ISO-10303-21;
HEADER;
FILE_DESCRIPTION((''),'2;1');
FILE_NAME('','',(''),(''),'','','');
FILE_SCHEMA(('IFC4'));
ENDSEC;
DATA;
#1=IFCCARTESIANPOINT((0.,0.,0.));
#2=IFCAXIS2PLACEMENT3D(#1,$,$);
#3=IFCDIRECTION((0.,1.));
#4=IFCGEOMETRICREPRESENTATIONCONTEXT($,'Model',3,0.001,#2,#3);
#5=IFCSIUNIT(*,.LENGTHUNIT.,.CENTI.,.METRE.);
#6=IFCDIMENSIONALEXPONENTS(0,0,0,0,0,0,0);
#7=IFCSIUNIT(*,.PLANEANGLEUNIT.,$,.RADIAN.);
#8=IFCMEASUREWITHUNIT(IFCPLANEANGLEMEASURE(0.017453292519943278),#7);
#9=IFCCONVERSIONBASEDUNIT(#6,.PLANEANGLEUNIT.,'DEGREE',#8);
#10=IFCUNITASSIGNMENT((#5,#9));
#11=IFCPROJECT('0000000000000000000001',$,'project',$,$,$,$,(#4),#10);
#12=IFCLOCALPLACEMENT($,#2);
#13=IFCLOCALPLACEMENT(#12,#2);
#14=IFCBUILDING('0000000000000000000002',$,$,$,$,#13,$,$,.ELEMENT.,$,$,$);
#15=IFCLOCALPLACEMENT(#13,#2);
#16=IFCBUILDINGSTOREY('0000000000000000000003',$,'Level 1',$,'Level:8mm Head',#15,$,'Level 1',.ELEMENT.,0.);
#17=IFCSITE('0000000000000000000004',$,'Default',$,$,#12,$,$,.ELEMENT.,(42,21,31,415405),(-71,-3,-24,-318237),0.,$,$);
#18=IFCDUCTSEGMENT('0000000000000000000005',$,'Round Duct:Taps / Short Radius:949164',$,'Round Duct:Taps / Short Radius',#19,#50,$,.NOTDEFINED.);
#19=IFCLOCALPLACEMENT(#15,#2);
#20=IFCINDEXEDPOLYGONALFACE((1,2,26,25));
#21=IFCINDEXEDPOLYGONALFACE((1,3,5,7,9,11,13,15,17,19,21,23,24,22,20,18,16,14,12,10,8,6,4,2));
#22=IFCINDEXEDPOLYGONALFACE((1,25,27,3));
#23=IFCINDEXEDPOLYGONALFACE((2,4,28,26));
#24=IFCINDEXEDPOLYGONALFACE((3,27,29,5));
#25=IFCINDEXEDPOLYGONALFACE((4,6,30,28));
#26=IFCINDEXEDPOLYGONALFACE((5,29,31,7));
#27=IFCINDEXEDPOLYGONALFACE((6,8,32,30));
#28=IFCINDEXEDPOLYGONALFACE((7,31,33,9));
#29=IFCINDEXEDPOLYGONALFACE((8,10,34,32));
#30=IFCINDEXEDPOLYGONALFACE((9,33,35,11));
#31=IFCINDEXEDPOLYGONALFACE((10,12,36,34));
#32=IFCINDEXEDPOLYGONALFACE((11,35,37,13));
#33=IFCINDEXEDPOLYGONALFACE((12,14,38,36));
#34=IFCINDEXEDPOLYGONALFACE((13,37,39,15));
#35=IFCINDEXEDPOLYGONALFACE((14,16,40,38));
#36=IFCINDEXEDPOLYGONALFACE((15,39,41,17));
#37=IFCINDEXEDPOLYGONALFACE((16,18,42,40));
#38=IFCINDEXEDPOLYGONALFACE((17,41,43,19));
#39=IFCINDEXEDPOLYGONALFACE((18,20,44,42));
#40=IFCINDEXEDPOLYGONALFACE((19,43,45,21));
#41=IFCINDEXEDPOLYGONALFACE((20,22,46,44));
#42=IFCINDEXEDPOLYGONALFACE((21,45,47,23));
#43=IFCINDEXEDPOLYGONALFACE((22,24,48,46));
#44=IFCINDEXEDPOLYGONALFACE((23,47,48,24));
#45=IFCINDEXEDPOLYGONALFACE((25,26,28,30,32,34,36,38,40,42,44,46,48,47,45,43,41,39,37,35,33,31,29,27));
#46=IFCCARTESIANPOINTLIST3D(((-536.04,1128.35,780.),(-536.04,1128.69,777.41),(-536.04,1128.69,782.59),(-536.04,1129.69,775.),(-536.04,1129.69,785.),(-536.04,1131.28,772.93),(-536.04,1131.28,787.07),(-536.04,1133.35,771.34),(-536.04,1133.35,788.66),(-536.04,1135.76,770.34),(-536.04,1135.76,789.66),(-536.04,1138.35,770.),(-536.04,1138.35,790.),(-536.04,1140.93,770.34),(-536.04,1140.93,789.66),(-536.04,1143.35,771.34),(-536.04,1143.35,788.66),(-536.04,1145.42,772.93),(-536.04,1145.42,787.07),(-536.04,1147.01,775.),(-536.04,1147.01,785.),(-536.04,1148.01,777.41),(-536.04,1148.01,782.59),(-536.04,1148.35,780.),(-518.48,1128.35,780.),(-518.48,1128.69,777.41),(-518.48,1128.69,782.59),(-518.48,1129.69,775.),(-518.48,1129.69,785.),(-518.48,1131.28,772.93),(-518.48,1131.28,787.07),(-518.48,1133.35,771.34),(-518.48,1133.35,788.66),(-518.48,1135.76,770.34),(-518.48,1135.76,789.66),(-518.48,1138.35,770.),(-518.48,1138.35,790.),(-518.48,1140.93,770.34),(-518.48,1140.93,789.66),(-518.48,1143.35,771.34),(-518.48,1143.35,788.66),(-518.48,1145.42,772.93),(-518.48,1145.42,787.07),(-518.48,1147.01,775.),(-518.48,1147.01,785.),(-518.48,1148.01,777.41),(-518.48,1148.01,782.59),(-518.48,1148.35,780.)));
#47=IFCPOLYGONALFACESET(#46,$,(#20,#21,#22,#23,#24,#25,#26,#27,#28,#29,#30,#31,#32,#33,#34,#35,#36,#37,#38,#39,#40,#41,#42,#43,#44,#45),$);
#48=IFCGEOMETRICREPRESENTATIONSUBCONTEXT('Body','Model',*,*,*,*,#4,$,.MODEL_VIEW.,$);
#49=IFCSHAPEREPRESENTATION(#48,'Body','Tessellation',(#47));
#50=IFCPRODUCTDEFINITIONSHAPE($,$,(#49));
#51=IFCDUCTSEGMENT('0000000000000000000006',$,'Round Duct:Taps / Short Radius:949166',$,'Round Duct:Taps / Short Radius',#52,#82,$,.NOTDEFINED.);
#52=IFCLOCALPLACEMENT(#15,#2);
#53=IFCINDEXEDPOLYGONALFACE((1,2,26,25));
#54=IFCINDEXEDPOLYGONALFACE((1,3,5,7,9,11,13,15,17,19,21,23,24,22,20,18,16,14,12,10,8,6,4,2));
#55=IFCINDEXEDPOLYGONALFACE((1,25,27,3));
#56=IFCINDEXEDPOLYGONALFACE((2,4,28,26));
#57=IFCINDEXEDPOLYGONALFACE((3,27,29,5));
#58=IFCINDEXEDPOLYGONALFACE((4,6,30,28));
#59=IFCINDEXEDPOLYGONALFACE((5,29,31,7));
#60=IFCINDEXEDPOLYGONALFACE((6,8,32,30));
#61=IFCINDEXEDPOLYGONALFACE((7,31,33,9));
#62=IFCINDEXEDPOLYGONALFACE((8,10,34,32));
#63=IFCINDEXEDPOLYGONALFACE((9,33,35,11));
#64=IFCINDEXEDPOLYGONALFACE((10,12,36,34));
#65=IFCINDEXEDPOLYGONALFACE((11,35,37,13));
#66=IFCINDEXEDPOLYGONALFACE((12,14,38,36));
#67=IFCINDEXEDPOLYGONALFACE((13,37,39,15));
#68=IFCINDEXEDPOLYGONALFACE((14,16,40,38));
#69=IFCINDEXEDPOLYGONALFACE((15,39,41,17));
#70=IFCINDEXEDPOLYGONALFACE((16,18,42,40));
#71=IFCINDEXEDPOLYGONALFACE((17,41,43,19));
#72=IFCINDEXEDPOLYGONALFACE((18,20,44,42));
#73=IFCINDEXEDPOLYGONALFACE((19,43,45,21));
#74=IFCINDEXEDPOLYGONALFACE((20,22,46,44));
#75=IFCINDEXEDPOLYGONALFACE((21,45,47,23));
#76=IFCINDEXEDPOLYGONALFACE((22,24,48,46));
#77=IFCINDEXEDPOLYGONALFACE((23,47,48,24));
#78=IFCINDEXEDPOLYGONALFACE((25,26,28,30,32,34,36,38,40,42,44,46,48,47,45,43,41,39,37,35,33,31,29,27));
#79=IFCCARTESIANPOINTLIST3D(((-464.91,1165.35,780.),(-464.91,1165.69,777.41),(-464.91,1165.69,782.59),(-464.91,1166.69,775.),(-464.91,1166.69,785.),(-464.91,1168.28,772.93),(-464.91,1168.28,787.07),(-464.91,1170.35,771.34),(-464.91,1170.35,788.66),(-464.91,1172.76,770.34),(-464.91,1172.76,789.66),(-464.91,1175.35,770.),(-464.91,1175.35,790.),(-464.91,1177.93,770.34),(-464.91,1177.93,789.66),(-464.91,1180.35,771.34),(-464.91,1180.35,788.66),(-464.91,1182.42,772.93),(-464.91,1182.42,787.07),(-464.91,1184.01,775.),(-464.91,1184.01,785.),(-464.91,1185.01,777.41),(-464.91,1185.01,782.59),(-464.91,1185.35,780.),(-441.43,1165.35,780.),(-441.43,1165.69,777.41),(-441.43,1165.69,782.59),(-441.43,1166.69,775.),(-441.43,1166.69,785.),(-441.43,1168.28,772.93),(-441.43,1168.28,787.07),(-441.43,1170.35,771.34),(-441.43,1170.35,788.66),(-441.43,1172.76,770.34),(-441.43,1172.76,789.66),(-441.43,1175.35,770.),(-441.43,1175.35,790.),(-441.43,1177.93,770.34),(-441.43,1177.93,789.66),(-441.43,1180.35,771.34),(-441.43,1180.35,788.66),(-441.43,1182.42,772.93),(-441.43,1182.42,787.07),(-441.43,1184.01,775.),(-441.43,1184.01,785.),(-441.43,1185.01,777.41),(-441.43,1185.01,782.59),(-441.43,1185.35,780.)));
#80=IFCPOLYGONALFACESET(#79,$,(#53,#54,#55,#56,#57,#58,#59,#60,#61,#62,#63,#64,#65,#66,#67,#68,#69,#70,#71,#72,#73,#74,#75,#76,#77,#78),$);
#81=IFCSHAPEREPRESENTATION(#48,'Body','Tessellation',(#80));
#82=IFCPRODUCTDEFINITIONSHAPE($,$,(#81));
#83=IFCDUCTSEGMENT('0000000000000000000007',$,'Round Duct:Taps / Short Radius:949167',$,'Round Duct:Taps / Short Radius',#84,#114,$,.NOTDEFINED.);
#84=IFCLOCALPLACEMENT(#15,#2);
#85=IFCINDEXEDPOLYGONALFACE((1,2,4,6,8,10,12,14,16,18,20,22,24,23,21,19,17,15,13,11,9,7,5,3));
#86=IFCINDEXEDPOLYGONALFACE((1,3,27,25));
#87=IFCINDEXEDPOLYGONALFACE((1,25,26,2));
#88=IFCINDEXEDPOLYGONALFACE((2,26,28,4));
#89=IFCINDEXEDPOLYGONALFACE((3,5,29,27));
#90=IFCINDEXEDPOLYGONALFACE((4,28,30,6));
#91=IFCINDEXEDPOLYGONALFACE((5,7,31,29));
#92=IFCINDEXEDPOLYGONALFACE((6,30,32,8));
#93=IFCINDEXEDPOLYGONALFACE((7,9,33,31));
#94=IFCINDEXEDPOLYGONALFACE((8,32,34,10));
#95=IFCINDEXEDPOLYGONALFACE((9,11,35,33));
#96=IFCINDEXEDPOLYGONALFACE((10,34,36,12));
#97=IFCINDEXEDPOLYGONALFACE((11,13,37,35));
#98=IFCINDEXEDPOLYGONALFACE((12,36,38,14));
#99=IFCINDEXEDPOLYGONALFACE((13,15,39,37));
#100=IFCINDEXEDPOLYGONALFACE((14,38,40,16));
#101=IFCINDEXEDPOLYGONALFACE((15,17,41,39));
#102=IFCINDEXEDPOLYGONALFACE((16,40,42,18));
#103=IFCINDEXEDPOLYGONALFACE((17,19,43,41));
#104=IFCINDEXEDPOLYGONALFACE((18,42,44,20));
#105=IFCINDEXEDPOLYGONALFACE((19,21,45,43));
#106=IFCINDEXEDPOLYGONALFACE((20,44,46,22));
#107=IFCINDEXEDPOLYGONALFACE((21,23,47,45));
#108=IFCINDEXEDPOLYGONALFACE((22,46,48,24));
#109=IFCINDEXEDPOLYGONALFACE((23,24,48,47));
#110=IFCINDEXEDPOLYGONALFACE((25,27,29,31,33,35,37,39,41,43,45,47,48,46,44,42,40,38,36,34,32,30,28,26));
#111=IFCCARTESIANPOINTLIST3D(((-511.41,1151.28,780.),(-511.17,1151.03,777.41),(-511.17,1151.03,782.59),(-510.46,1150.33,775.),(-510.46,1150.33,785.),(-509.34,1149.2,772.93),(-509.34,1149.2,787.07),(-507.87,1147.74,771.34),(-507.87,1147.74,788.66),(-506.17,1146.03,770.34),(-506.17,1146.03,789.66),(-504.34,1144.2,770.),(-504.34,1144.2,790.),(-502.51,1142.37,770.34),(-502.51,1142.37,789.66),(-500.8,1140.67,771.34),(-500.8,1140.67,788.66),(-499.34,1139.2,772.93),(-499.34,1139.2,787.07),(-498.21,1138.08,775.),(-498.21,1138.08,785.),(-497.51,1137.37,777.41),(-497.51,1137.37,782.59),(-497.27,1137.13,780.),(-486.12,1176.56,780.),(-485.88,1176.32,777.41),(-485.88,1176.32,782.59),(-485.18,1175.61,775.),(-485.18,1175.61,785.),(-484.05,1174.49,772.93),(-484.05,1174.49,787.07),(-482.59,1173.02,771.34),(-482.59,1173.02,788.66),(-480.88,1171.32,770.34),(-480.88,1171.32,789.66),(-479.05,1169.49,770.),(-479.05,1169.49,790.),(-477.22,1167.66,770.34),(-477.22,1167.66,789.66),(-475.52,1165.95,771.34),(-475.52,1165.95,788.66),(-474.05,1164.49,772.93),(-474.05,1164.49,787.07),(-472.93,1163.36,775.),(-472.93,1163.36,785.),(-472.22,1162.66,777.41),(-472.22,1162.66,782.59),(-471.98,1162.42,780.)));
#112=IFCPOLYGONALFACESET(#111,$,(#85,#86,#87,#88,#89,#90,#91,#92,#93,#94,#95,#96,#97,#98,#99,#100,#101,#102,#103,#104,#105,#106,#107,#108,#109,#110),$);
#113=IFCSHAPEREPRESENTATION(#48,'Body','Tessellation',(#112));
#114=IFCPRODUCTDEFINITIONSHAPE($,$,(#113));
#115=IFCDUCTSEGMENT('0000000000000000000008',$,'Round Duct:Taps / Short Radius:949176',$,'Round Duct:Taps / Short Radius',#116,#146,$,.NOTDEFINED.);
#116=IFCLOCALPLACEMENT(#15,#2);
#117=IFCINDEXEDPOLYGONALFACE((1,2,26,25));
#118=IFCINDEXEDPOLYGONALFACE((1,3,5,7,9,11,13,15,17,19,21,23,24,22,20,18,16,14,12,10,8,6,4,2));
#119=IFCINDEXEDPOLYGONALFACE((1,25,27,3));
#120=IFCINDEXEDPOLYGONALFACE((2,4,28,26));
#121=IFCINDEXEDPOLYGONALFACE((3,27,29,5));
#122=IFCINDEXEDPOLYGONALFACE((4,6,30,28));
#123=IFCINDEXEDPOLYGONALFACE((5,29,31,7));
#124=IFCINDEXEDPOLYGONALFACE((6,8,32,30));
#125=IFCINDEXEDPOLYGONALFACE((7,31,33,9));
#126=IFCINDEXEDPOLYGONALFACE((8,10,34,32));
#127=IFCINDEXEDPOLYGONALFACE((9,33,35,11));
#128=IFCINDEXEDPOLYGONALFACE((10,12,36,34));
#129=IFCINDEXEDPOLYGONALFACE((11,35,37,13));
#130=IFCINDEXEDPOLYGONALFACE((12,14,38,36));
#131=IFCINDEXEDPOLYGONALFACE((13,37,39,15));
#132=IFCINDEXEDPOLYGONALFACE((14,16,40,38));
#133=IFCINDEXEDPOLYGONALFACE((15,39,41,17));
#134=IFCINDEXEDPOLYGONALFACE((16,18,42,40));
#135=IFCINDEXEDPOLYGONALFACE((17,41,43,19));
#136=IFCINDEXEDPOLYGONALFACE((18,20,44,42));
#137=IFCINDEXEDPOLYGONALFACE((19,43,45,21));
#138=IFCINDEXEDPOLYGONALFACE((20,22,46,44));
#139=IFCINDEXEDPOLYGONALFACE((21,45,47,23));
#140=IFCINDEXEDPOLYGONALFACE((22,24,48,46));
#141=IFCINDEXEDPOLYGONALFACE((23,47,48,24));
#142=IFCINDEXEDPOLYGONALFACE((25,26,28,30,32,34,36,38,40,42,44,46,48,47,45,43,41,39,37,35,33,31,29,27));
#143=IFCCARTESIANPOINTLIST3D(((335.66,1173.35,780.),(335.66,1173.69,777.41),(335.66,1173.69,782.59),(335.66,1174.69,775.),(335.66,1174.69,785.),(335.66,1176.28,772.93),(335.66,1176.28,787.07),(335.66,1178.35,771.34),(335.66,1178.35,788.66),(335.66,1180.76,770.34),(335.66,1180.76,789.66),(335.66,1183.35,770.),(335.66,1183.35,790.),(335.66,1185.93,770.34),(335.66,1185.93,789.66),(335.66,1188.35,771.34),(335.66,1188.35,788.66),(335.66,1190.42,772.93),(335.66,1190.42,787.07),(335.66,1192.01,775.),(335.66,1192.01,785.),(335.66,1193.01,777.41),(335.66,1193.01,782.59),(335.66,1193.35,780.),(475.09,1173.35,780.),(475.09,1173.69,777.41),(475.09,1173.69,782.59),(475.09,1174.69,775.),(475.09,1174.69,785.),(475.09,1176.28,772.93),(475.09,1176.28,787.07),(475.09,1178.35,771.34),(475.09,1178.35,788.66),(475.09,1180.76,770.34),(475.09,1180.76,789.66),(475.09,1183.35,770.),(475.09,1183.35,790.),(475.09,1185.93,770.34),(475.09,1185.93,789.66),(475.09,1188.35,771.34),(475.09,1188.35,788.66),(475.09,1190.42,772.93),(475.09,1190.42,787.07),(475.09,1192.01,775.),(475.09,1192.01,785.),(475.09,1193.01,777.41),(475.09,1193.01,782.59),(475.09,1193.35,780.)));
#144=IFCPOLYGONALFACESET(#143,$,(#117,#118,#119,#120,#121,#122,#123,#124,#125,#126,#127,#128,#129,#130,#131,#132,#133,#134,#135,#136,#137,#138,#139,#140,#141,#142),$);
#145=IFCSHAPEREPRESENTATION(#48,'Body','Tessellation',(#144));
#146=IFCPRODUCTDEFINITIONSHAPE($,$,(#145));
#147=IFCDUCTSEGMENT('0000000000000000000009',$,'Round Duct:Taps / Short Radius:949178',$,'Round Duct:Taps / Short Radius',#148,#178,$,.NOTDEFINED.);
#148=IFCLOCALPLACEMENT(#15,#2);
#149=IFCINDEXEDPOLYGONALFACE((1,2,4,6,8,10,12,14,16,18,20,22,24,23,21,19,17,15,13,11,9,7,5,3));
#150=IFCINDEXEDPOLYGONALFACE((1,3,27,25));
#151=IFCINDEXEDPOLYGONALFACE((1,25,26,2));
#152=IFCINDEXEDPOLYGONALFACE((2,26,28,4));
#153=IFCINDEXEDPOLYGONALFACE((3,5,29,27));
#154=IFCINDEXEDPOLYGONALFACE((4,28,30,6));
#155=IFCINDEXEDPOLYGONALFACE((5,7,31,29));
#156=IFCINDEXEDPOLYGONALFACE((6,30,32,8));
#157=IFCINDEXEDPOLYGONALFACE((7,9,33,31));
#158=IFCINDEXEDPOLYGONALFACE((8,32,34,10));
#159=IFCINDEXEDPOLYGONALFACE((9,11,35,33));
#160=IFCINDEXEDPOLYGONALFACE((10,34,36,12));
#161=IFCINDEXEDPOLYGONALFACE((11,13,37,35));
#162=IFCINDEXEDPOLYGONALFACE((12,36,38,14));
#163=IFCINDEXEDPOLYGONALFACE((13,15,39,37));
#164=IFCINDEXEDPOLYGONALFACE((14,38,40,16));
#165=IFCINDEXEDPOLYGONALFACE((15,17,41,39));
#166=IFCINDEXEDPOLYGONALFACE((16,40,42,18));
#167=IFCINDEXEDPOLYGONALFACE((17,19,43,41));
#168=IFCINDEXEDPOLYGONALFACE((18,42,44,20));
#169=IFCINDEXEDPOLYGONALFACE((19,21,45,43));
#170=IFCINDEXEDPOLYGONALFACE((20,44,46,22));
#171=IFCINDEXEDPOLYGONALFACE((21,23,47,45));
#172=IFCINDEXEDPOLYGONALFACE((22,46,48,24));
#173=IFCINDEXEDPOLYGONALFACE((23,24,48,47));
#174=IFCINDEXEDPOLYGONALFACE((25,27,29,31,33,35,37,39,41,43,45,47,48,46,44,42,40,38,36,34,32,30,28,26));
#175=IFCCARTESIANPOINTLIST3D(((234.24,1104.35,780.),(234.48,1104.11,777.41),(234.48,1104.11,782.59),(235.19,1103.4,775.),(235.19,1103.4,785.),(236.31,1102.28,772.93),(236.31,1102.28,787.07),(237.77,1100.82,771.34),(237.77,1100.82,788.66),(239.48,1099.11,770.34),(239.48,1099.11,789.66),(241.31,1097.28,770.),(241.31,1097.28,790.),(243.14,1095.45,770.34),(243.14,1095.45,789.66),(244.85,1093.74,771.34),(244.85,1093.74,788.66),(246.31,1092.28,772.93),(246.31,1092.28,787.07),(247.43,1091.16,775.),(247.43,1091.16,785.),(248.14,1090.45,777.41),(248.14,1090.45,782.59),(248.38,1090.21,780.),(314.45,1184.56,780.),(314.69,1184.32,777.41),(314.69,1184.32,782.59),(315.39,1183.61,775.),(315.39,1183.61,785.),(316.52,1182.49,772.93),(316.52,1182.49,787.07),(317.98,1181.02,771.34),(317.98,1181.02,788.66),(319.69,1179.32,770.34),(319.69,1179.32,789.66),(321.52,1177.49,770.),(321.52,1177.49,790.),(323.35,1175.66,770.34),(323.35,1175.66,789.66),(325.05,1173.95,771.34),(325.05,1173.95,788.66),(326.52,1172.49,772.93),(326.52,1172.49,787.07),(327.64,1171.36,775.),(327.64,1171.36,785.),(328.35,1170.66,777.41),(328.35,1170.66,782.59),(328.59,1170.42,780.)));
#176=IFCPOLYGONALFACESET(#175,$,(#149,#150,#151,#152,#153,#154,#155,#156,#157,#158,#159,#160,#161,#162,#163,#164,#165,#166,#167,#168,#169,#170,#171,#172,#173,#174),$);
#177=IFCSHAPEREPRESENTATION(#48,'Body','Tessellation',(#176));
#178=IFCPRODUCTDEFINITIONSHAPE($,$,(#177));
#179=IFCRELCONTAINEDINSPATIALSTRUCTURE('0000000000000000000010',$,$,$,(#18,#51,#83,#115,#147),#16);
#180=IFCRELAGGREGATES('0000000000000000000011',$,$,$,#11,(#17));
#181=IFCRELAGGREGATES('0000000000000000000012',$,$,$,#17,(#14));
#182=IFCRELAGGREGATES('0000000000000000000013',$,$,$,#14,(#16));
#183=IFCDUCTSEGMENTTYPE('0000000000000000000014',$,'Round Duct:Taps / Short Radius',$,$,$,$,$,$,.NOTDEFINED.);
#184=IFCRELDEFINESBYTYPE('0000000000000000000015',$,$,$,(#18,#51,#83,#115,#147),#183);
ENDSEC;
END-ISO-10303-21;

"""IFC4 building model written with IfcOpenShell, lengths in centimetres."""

from ifc_helpers import new_model, entity, si_unit, converted_unit, direction, frame, origin, place, context, subcontext, project, spatial, arc, indexed_curve, outline, extrude, type_object, element, save


model = new_model("IFC4")

# Units and contexts
model_context = context("Model", 3, precision=0.001, world=origin(), true_north=direction((0.0, 1.0)))
body_context = subcontext(model_context, "Body", "Model", "MODEL_VIEW")
ifc_project = project(units=[si_unit("LENGTHUNIT", "METRE", prefix="CENTI"), converted_unit("PLANEANGLEUNIT", "DEGREE", entity("IfcPlaneAngleMeasure", 0.017453292519943278), si_unit("PLANEANGLEUNIT", "RADIAN"), dimensions=[0, 0, 0, 0, 0, 0, 0])], contexts=[model_context])

# Site, building, storey
site_placement = place(None, origin())
site = spatial("IfcSite", under=ifc_project, at=site_placement, Name="Default", CompositionType="ELEMENT", RefLatitude=(42, 21, 31, 415405), RefLongitude=(-71, -3, -24, -318237), RefElevation=0.0)
building_placement = place(site_placement, origin())
building = spatial("IfcBuilding", under=site, at=building_placement, CompositionType="ELEMENT")
storey_placement = place(building_placement, origin())
storey = spatial("IfcBuildingStorey", under=building, at=storey_placement, Name="Level 1", ObjectType="Level:8mm Head", LongName="Level 1", CompositionType="ELEMENT", Elevation=0.0)

# Duct segments
duct_segment_type_1 = type_object("IfcDuctSegmentType", Name="Round Duct:Taps / Short Radius", PredefinedType="NOTDEFINED")
duct_segment_1_placement = place(storey_placement, origin())
element("IfcDuctSegment", 1, at=duct_segment_1_placement, inside=storey, type_object=duct_segment_type_1, Name="Round Duct:Taps / Short Radius:949164", ObjectType="Round Duct:Taps / Short Radius", PredefinedType="NOTDEFINED", context=body_context, shape_type="SweptSolid", body=[
    extrude(outline(indexed_curve([(10.0, 0.0), (7.07, 7.07), (0.0, 10.0), (-7.07, 7.07), (-10.0, 0.0), (-7.07, -7.07), (0.0, -10.0), (7.07, -7.07)], segments=[arc(1, 2, 3), arc(3, 4, 5), arc(5, 6, 7), arc(7, 8, 1)], self_intersect=False)), frame((-536.04, 1138.35, 780.0), z_axis=(1.0, 0.0, 0.0), x_axis=(0.0, 1.0, 0.0)), (0.0, 0.0, 1.0), 17.56),
])
duct_segment_2_placement = place(storey_placement, origin())
element("IfcDuctSegment", 2, at=duct_segment_2_placement, inside=storey, type_object=duct_segment_type_1, Name="Round Duct:Taps / Short Radius:949166", ObjectType="Round Duct:Taps / Short Radius", PredefinedType="NOTDEFINED", context=body_context, shape_type="SweptSolid", body=[
    extrude(outline(indexed_curve([(10.0, 0.0), (7.07, 7.07), (0.0, 10.0), (-7.07, 7.07), (-10.0, 0.0), (-7.07, -7.07), (0.0, -10.0), (7.07, -7.07)], segments=[arc(1, 2, 3), arc(3, 4, 5), arc(5, 6, 7), arc(7, 8, 1)], self_intersect=False)), frame((-464.91, 1175.35, 780.0), z_axis=(1.0, 0.0, 0.0), x_axis=(0.0, -1.0, 0.0)), (0.0, 0.0, 1.0), 23.48),
])
duct_segment_3_placement = place(storey_placement, origin())
element("IfcDuctSegment", 3, at=duct_segment_3_placement, inside=storey, type_object=duct_segment_type_1, Name="Round Duct:Taps / Short Radius:949167", ObjectType="Round Duct:Taps / Short Radius", PredefinedType="NOTDEFINED", context=body_context, shape_type="SweptSolid", body=[
    extrude(outline(indexed_curve([(10.0, 0.0), (7.07, 7.07), (0.0, 10.0), (-7.07, 7.07), (-10.0, 0.0), (-7.07, -7.07), (0.0, -10.0), (7.07, -7.07)], segments=[arc(1, 2, 3), arc(3, 4, 5), arc(5, 6, 7), arc(7, 8, 1)], self_intersect=False)), frame((-504.34, 1144.2, 780.0), z_axis=(0.707107, 0.707107, 0.0), x_axis=(-0.707107, 0.707107, 0.0)), (0.0, 0.0, 1.0), 35.76),
])
duct_segment_4_placement = place(storey_placement, origin())
element("IfcDuctSegment", 4, at=duct_segment_4_placement, inside=storey, type_object=duct_segment_type_1, Name="Round Duct:Taps / Short Radius:949176", ObjectType="Round Duct:Taps / Short Radius", PredefinedType="NOTDEFINED", context=body_context, shape_type="SweptSolid", body=[
    extrude(outline(indexed_curve([(10.0, 0.0), (7.07, 7.07), (0.0, 10.0), (-7.07, 7.07), (-10.0, 0.0), (-7.07, -7.07), (0.0, -10.0), (7.07, -7.07)], segments=[arc(1, 2, 3), arc(3, 4, 5), arc(5, 6, 7), arc(7, 8, 1)], self_intersect=False)), frame((335.66, 1183.35, 780.0), z_axis=(1.0, 0.0, 0.0), x_axis=(0.0, -1.0, 0.0)), (0.0, 0.0, 1.0), 139.43),
])
duct_segment_5_placement = place(storey_placement, origin())
element("IfcDuctSegment", 5, at=duct_segment_5_placement, inside=storey, type_object=duct_segment_type_1, Name="Round Duct:Taps / Short Radius:949178", ObjectType="Round Duct:Taps / Short Radius", PredefinedType="NOTDEFINED", context=body_context, shape_type="SweptSolid", body=[
    extrude(outline(indexed_curve([(10.0, 0.0), (7.07, 7.07), (0.0, 10.0), (-7.07, 7.07), (-10.0, 0.0), (-7.07, -7.07), (0.0, -10.0), (7.07, -7.07)], segments=[arc(1, 2, 3), arc(3, 4, 5), arc(5, 6, 7), arc(7, 8, 1)], self_intersect=False)), frame((241.31, 1097.28, 780.0), z_axis=(0.707107, 0.707107, 0.0), x_axis=(-0.707107, 0.707107, 0.0)), (0.0, 0.0, 1.0), 113.43),
])

save(model, "model.ifc")
